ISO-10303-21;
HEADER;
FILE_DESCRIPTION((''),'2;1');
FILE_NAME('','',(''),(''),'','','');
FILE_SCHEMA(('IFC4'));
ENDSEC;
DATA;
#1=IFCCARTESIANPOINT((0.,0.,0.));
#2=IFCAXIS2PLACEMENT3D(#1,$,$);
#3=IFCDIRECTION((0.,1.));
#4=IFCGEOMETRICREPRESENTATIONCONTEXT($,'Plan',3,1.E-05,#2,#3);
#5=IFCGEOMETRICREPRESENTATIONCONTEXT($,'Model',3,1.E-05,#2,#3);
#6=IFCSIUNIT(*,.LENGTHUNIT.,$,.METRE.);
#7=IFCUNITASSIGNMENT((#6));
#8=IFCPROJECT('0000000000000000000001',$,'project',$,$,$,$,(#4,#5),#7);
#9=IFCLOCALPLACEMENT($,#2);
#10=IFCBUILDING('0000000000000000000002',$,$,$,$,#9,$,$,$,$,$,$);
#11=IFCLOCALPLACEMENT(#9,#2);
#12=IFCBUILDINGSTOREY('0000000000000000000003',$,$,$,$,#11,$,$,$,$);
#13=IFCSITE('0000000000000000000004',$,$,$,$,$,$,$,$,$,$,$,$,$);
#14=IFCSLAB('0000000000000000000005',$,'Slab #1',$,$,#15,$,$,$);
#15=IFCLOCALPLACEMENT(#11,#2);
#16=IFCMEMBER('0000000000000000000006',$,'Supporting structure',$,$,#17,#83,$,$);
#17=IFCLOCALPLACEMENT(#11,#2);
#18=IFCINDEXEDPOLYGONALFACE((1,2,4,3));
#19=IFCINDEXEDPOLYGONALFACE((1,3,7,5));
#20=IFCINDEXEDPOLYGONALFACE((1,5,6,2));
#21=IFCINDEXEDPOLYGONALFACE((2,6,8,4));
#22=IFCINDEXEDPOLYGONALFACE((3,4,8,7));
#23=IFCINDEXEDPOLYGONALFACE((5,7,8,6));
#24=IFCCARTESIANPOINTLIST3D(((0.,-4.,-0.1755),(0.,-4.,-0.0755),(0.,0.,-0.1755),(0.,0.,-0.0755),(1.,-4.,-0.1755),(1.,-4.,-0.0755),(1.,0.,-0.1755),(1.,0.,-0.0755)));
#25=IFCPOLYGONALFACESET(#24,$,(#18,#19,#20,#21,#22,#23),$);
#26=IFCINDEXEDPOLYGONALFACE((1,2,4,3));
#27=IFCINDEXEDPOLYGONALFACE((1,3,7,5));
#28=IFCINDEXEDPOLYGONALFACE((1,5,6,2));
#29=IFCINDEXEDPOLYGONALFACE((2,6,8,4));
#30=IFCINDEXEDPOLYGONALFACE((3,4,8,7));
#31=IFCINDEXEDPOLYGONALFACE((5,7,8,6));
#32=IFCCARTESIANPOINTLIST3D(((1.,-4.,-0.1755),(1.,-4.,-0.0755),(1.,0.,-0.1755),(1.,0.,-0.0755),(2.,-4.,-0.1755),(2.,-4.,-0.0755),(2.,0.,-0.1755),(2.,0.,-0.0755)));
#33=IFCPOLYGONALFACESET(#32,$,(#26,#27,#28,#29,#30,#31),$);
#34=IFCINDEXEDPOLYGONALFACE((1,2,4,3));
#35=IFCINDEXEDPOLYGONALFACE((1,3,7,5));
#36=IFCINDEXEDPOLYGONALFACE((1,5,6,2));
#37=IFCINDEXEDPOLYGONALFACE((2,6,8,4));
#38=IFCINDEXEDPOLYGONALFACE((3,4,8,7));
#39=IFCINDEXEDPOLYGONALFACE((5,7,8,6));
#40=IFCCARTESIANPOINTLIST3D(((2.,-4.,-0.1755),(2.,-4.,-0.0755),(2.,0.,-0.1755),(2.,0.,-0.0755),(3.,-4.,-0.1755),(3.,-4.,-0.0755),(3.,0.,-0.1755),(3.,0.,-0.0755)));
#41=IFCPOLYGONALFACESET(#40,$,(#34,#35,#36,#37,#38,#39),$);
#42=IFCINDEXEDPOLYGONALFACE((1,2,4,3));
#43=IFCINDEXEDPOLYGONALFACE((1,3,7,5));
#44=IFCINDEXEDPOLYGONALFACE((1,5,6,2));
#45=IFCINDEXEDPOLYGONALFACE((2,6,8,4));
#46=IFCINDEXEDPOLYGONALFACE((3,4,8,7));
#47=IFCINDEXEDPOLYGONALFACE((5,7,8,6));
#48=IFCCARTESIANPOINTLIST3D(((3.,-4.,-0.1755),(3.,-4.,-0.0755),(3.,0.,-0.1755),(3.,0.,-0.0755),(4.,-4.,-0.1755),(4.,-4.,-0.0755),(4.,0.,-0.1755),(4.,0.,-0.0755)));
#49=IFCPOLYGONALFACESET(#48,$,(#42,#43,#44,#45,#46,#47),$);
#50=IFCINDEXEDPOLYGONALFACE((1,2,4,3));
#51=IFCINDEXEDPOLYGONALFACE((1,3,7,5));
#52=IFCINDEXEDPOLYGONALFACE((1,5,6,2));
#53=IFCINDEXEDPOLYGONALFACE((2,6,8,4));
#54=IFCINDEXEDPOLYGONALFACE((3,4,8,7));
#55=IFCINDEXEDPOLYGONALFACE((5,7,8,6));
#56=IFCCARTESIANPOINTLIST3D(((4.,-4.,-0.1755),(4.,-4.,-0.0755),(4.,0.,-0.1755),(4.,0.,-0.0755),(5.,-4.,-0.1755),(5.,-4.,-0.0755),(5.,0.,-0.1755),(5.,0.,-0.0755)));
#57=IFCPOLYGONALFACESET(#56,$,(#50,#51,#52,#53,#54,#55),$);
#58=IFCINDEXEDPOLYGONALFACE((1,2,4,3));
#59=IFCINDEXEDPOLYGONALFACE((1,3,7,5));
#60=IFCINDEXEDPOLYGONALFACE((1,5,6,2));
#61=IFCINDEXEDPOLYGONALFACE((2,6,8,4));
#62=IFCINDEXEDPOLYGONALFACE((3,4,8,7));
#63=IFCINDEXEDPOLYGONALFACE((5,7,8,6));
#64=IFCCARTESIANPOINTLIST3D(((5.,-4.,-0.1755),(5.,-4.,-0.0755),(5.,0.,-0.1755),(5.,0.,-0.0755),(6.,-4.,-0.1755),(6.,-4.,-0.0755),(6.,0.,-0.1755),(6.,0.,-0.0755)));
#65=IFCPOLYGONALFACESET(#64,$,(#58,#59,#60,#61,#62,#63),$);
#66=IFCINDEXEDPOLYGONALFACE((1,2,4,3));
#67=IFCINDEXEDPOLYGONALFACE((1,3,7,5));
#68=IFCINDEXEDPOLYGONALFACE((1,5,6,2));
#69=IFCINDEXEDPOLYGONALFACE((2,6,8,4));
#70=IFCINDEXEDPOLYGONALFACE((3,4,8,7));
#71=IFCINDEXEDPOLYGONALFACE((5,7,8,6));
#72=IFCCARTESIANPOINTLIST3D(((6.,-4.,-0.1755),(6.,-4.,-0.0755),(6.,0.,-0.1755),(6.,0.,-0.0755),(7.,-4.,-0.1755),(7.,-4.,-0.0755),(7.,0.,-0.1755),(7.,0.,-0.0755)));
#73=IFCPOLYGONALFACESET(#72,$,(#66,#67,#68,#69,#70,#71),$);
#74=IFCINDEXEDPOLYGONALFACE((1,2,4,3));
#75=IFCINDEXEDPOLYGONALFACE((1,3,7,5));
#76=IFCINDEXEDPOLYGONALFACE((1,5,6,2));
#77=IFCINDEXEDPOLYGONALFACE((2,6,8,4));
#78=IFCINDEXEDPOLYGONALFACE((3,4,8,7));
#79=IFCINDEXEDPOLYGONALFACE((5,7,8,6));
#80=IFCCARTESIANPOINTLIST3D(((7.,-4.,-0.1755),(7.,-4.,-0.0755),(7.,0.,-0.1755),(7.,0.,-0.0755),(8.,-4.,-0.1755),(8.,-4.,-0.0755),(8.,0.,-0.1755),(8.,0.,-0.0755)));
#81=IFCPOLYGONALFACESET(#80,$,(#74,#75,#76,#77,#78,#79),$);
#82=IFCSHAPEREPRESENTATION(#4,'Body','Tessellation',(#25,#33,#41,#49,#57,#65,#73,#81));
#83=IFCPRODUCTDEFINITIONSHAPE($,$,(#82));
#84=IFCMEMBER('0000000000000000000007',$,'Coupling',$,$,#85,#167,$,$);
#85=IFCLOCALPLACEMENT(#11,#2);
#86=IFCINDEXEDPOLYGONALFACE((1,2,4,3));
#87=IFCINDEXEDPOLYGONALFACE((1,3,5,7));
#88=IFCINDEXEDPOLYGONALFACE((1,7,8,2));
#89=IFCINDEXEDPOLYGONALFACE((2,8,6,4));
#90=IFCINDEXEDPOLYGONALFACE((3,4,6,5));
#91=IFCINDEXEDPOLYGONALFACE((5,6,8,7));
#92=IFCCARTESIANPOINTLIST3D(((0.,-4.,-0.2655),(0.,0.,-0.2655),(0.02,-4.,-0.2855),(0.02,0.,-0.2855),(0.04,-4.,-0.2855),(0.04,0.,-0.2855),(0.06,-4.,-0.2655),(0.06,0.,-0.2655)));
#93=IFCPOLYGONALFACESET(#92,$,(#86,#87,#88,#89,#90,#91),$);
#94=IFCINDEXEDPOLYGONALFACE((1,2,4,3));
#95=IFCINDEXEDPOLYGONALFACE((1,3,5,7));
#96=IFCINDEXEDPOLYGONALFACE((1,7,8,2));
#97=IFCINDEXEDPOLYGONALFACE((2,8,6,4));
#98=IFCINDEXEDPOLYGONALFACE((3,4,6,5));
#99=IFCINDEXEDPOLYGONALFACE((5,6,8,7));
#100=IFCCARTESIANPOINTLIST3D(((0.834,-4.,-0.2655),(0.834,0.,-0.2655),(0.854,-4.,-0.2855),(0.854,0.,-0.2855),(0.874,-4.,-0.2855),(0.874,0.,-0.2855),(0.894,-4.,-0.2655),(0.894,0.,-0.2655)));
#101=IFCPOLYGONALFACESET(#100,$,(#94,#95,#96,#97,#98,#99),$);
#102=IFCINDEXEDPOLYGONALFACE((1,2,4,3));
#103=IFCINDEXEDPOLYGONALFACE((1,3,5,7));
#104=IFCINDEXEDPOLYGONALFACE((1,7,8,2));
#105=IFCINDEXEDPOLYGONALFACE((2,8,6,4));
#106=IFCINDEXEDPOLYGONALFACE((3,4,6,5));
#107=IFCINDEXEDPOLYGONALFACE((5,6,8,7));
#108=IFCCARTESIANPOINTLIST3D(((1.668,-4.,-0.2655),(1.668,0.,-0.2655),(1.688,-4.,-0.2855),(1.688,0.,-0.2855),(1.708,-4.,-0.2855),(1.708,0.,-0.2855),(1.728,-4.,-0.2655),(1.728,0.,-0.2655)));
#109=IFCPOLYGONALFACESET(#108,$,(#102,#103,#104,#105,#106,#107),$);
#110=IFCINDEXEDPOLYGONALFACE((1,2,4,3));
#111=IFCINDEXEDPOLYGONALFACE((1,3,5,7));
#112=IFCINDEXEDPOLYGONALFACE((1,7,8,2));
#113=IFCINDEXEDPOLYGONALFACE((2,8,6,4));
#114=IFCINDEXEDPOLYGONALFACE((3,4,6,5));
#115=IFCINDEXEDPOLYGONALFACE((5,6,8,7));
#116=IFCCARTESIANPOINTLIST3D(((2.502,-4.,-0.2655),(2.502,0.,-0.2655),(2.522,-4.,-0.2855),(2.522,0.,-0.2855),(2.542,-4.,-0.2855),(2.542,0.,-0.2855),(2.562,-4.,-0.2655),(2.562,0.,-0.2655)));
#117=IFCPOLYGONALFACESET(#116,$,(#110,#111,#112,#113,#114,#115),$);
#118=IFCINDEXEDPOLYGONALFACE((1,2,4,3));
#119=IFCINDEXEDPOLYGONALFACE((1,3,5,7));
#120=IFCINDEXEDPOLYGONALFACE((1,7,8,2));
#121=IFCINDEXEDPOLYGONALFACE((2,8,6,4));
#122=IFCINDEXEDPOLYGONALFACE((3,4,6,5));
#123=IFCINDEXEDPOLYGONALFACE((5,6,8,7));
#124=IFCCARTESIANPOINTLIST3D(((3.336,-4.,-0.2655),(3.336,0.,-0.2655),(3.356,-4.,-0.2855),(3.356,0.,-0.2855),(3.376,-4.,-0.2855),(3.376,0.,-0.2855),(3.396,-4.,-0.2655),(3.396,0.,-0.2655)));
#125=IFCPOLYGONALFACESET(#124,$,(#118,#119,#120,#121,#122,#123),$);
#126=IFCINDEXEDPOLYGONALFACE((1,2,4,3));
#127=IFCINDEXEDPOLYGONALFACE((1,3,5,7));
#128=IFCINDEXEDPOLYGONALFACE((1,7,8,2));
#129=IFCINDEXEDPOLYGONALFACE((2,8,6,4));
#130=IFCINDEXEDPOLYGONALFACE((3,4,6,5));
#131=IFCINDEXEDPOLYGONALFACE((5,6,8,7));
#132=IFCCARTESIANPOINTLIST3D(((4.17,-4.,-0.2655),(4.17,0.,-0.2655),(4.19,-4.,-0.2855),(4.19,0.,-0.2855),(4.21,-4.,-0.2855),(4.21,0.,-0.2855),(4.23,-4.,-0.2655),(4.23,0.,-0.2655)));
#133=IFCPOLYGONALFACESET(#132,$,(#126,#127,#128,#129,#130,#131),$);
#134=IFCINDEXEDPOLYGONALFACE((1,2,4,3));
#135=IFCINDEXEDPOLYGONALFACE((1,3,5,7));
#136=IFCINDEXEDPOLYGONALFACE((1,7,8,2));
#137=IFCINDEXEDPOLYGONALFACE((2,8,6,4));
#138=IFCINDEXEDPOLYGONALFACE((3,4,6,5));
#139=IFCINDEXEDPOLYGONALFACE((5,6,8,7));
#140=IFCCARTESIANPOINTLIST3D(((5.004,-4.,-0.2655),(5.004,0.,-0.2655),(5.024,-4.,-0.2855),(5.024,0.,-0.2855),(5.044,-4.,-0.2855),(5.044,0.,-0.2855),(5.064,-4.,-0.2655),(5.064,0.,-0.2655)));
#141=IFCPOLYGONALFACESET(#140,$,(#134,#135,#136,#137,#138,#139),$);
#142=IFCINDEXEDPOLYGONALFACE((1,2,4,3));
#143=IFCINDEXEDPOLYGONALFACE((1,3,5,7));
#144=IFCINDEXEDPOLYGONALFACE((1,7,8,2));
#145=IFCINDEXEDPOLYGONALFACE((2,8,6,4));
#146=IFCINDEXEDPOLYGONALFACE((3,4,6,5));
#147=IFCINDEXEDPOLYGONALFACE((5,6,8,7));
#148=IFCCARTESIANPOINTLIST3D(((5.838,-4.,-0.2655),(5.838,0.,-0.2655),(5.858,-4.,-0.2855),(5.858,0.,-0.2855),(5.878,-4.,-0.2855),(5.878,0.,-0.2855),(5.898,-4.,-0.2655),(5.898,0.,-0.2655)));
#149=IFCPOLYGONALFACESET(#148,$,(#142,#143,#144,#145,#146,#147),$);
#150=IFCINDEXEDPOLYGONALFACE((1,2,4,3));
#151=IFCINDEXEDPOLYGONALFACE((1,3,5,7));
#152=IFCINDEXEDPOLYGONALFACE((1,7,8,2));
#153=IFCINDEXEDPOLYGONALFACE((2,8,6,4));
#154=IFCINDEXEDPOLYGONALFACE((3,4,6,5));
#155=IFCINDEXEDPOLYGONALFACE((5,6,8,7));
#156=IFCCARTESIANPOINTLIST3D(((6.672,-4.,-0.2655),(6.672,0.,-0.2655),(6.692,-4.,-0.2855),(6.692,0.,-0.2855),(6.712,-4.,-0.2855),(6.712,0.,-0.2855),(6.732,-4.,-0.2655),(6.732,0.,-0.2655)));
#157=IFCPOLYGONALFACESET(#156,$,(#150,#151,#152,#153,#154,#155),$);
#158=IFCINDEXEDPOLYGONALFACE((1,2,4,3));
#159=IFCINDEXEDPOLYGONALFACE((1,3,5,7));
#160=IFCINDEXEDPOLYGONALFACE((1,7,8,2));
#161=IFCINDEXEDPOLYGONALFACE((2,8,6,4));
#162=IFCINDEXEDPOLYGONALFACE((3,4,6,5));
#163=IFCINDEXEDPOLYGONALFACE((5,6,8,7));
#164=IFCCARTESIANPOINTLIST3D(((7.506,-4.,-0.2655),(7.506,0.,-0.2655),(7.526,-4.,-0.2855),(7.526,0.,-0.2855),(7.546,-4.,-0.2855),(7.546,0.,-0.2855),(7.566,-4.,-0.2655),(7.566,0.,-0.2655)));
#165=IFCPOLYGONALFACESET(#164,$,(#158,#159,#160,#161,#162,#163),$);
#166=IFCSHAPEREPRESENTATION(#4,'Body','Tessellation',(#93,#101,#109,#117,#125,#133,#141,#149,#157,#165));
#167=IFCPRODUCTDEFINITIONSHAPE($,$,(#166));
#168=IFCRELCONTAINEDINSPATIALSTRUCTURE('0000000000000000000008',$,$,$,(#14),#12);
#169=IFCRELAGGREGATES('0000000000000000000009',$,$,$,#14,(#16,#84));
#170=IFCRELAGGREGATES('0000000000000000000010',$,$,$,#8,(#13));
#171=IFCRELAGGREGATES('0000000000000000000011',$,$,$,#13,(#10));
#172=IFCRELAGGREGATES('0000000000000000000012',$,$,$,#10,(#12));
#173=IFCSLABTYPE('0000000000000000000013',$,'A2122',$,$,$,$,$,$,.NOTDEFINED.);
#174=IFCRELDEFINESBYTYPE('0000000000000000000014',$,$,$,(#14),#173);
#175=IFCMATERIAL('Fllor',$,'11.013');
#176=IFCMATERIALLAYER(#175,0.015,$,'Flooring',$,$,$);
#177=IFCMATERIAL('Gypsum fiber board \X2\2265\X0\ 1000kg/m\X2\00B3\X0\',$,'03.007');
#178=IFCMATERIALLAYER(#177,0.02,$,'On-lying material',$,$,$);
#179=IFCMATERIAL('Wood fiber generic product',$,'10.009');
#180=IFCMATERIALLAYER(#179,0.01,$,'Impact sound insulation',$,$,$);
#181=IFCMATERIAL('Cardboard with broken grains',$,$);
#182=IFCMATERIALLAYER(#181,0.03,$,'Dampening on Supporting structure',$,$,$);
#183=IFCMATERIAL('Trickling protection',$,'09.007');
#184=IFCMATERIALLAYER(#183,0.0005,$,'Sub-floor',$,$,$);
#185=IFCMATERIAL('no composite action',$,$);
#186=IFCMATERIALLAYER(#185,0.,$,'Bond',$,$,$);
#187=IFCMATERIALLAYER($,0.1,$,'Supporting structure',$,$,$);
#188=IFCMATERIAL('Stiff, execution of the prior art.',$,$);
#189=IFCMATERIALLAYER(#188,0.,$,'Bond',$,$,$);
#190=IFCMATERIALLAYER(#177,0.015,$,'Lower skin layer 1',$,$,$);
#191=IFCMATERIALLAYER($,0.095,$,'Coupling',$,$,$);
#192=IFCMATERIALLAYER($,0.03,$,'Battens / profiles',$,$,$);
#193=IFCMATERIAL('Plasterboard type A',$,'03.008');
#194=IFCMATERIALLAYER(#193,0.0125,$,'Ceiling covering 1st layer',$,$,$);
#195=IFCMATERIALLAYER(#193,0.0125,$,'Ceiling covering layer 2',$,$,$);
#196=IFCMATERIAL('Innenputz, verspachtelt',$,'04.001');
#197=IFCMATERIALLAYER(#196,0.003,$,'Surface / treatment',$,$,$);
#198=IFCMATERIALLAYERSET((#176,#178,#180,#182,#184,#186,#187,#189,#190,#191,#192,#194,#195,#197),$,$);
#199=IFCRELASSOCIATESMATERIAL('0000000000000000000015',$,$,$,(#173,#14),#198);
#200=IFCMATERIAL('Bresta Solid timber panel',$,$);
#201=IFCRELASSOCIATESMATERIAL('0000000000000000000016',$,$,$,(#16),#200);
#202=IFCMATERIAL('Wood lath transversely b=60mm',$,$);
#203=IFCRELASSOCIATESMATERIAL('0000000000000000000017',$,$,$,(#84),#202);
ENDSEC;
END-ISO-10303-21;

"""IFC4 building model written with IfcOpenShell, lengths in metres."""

from ifc_helpers import new_model, si_unit, direction, frame, frame_2d, origin, place, context, project, spatial, polyline, rectangle, outline, extrude, material, layer, layer_set, type_object, element, aggregate, save


model = new_model("IFC4")

# Units and contexts
plan_context = context("Plan", 3, precision=1e-05, world=origin(), true_north=direction((0.0, 1.0)))
model_context = context("Model", 3, precision=1e-05, world=origin(), true_north=direction((0.0, 1.0)))
ifc_project = project(units=[si_unit("LENGTHUNIT", "METRE")], contexts=[plan_context, model_context])

# Site, building, storey
site = spatial("IfcSite", under=ifc_project)
building_placement = place(None, origin())
building = spatial("IfcBuilding", under=site, at=building_placement)
storey_placement = place(building_placement, origin())
storey = spatial("IfcBuildingStorey", under=building, at=storey_placement)

# Slab, members
ifc_material_1 = material(Name="Fllor", Category="11.013")
ifc_layer_1 = layer(ifc_material_1, 0.015, Name="Flooring")
ifc_material_2 = material(Name="Gypsum fiber board ≥ 1000kg/m³", Category="03.007")
ifc_layer_2 = layer(ifc_material_2, 0.02, Name="On-lying material")
ifc_material_3 = material(Name="Wood fiber generic product", Category="10.009")
ifc_layer_3 = layer(ifc_material_3, 0.01, Name="Impact sound insulation")
ifc_material_4 = material(Name="Cardboard with broken grains")
ifc_layer_4 = layer(ifc_material_4, 0.03, Name="Dampening on Supporting structure")
ifc_material_5 = material(Name="Trickling protection", Category="09.007")
ifc_layer_5 = layer(ifc_material_5, 0.0005, Name="Sub-floor")
ifc_material_6 = material(Name="no composite action")
ifc_layer_6 = layer(ifc_material_6, 0.0, Name="Bond")
ifc_layer_7 = layer(None, 0.1, Name="Supporting structure")
ifc_material_7 = material(Name="Stiff, execution of the prior art.")
ifc_layer_8 = layer(ifc_material_7, 0.0, Name="Bond")
ifc_layer_9 = layer(ifc_material_2, 0.015, Name="Lower skin layer 1")
ifc_layer_10 = layer(None, 0.095, Name="Coupling")
ifc_layer_11 = layer(None, 0.03, Name="Battens / profiles")
ifc_material_8 = material(Name="Plasterboard type A", Category="03.008")
ifc_layer_12 = layer(ifc_material_8, 0.0125, Name="Ceiling covering 1st layer")
ifc_layer_13 = layer(ifc_material_8, 0.0125, Name="Ceiling covering layer 2")
ifc_material_9 = material(Name="Innenputz, verspachtelt", Category="04.001")
ifc_layer_14 = layer(ifc_material_9, 0.003, Name="Surface / treatment")
ifc_layer_set = layer_set([ifc_layer_1, ifc_layer_2, ifc_layer_3, ifc_layer_4, ifc_layer_5, ifc_layer_6, ifc_layer_7, ifc_layer_8, ifc_layer_9, ifc_layer_10, ifc_layer_11, ifc_layer_12, ifc_layer_13, ifc_layer_14])
slab_type = type_object("IfcSlabType", Name="A2122", PredefinedType="NOTDEFINED", material=ifc_layer_set)
slab_placement = place(None, frame((0.0, 0.0, 0.0), z_axis=(0.0, 0.0, -1.0), x_axis=(1.0, 0.0, 0.0)))
slab = element("IfcSlab", 1, at=slab_placement, inside=storey, type_object=slab_type, material=ifc_layer_set, Name="Slab #1")
ifc_material_10 = material(Name="Bresta Solid timber panel")
member_1_placement = place(slab_placement, origin())
member_1 = element("IfcMember", 2, at=member_1_placement, material=ifc_material_10, Name="Supporting structure", context=plan_context, shape_type="SweptSolid", body=[
    extrude(rectangle(XDim=1.0, YDim=0.1, at=frame_2d((0.5, 0.05), x_axis=(1.0, 0.0))), frame((0.0, 4.0, 0.0755), z_axis=(0.0, -1.0, 0.0), x_axis=(1.0, 0.0, 0.0)), (0.0, 0.0, 1.0), 4.0),
    extrude(rectangle(XDim=1.0, YDim=0.1, at=frame_2d((0.5, 0.05), x_axis=(1.0, 0.0))), frame((1.0, 4.0, 0.0755), z_axis=(0.0, -1.0, 0.0), x_axis=(1.0, 0.0, 0.0)), (0.0, 0.0, 1.0), 4.0),
    extrude(rectangle(XDim=1.0, YDim=0.1, at=frame_2d((0.5, 0.05), x_axis=(1.0, 0.0))), frame((2.0, 4.0, 0.0755), z_axis=(0.0, -1.0, 0.0), x_axis=(1.0, 0.0, 0.0)), (0.0, 0.0, 1.0), 4.0),
    extrude(rectangle(XDim=1.0, YDim=0.1, at=frame_2d((0.5, 0.05), x_axis=(1.0, 0.0))), frame((3.0, 4.0, 0.0755), z_axis=(0.0, -1.0, 0.0), x_axis=(1.0, 0.0, 0.0)), (0.0, 0.0, 1.0), 4.0),
    extrude(rectangle(XDim=1.0, YDim=0.1, at=frame_2d((0.5, 0.05), x_axis=(1.0, 0.0))), frame((4.0, 4.0, 0.0755), z_axis=(0.0, -1.0, 0.0), x_axis=(1.0, 0.0, 0.0)), (0.0, 0.0, 1.0), 4.0),
    extrude(rectangle(XDim=1.0, YDim=0.1, at=frame_2d((0.5, 0.05), x_axis=(1.0, 0.0))), frame((5.0, 4.0, 0.0755), z_axis=(0.0, -1.0, 0.0), x_axis=(1.0, 0.0, 0.0)), (0.0, 0.0, 1.0), 4.0),
    extrude(rectangle(XDim=1.0, YDim=0.1, at=frame_2d((0.5, 0.05), x_axis=(1.0, 0.0))), frame((6.0, 4.0, 0.0755), z_axis=(0.0, -1.0, 0.0), x_axis=(1.0, 0.0, 0.0)), (0.0, 0.0, 1.0), 4.0),
    extrude(rectangle(XDim=1.0, YDim=0.1, at=frame_2d((0.5, 0.05), x_axis=(1.0, 0.0))), frame((7.0, 4.0, 0.0755), z_axis=(0.0, -1.0, 0.0), x_axis=(1.0, 0.0, 0.0)), (0.0, 0.0, 1.0), 4.0),
])
ifc_material_11 = material(Name="Wood lath transversely b=60mm")
member_2_placement = place(slab_placement, origin())
member_2 = element("IfcMember", 3, at=member_2_placement, material=ifc_material_11, Name="Coupling", context=plan_context, shape_type="SweptSolid", body=[
    extrude(outline(polyline([(0.0, 0.0), (0.06, 0.0), (0.04, 0.02), (0.02, 0.02), (0.0, 0.0)])), frame((0.0, 4.0, 0.2655), z_axis=(0.0, -1.0, 0.0), x_axis=(1.0, 0.0, 0.0)), (0.0, 0.0, 1.0), 4.0),
    extrude(outline(polyline([(0.0, 0.0), (0.06, 0.0), (0.04, 0.02), (0.02, 0.02), (0.0, 0.0)])), frame((0.834, 4.0, 0.2655), z_axis=(0.0, -1.0, 0.0), x_axis=(1.0, 0.0, 0.0)), (0.0, 0.0, 1.0), 4.0),
    extrude(outline(polyline([(0.0, 0.0), (0.06, 0.0), (0.04, 0.02), (0.02, 0.02), (0.0, 0.0)])), frame((1.668, 4.0, 0.2655), z_axis=(0.0, -1.0, 0.0), x_axis=(1.0, 0.0, 0.0)), (0.0, 0.0, 1.0), 4.0),
    extrude(outline(polyline([(0.0, 0.0), (0.06, 0.0), (0.04, 0.02), (0.02, 0.02), (0.0, 0.0)])), frame((2.502, 4.0, 0.2655), z_axis=(0.0, -1.0, 0.0), x_axis=(1.0, 0.0, 0.0)), (0.0, 0.0, 1.0), 4.0),
    extrude(outline(polyline([(0.0, 0.0), (0.06, 0.0), (0.04, 0.02), (0.02, 0.02), (0.0, 0.0)])), frame((3.336, 4.0, 0.2655), z_axis=(0.0, -1.0, 0.0), x_axis=(1.0, 0.0, 0.0)), (0.0, 0.0, 1.0), 4.0),
    extrude(outline(polyline([(0.0, 0.0), (0.06, 0.0), (0.04, 0.02), (0.02, 0.02), (0.0, 0.0)])), frame((4.17, 4.0, 0.2655), z_axis=(0.0, -1.0, 0.0), x_axis=(1.0, 0.0, 0.0)), (0.0, 0.0, 1.0), 4.0),
    extrude(outline(polyline([(0.0, 0.0), (0.06, 0.0), (0.04, 0.02), (0.02, 0.02), (0.0, 0.0)])), frame((5.004, 4.0, 0.2655), z_axis=(0.0, -1.0, 0.0), x_axis=(1.0, 0.0, 0.0)), (0.0, 0.0, 1.0), 4.0),
    extrude(outline(polyline([(0.0, 0.0), (0.06, 0.0), (0.04, 0.02), (0.02, 0.02), (0.0, 0.0)])), frame((5.838, 4.0, 0.2655), z_axis=(0.0, -1.0, 0.0), x_axis=(1.0, 0.0, 0.0)), (0.0, 0.0, 1.0), 4.0),
    extrude(outline(polyline([(0.0, 0.0), (0.06, 0.0), (0.04, 0.02), (0.02, 0.02), (0.0, 0.0)])), frame((6.672, 4.0, 0.2655), z_axis=(0.0, -1.0, 0.0), x_axis=(1.0, 0.0, 0.0)), (0.0, 0.0, 1.0), 4.0),
    extrude(outline(polyline([(0.0, 0.0), (0.06, 0.0), (0.04, 0.02), (0.02, 0.02), (0.0, 0.0)])), frame((7.506, 4.0, 0.2655), z_axis=(0.0, -1.0, 0.0), x_axis=(1.0, 0.0, 0.0)), (0.0, 0.0, 1.0), 4.0),
])
aggregate(slab, [member_1, member_2])

save(model, "model.ifc")
